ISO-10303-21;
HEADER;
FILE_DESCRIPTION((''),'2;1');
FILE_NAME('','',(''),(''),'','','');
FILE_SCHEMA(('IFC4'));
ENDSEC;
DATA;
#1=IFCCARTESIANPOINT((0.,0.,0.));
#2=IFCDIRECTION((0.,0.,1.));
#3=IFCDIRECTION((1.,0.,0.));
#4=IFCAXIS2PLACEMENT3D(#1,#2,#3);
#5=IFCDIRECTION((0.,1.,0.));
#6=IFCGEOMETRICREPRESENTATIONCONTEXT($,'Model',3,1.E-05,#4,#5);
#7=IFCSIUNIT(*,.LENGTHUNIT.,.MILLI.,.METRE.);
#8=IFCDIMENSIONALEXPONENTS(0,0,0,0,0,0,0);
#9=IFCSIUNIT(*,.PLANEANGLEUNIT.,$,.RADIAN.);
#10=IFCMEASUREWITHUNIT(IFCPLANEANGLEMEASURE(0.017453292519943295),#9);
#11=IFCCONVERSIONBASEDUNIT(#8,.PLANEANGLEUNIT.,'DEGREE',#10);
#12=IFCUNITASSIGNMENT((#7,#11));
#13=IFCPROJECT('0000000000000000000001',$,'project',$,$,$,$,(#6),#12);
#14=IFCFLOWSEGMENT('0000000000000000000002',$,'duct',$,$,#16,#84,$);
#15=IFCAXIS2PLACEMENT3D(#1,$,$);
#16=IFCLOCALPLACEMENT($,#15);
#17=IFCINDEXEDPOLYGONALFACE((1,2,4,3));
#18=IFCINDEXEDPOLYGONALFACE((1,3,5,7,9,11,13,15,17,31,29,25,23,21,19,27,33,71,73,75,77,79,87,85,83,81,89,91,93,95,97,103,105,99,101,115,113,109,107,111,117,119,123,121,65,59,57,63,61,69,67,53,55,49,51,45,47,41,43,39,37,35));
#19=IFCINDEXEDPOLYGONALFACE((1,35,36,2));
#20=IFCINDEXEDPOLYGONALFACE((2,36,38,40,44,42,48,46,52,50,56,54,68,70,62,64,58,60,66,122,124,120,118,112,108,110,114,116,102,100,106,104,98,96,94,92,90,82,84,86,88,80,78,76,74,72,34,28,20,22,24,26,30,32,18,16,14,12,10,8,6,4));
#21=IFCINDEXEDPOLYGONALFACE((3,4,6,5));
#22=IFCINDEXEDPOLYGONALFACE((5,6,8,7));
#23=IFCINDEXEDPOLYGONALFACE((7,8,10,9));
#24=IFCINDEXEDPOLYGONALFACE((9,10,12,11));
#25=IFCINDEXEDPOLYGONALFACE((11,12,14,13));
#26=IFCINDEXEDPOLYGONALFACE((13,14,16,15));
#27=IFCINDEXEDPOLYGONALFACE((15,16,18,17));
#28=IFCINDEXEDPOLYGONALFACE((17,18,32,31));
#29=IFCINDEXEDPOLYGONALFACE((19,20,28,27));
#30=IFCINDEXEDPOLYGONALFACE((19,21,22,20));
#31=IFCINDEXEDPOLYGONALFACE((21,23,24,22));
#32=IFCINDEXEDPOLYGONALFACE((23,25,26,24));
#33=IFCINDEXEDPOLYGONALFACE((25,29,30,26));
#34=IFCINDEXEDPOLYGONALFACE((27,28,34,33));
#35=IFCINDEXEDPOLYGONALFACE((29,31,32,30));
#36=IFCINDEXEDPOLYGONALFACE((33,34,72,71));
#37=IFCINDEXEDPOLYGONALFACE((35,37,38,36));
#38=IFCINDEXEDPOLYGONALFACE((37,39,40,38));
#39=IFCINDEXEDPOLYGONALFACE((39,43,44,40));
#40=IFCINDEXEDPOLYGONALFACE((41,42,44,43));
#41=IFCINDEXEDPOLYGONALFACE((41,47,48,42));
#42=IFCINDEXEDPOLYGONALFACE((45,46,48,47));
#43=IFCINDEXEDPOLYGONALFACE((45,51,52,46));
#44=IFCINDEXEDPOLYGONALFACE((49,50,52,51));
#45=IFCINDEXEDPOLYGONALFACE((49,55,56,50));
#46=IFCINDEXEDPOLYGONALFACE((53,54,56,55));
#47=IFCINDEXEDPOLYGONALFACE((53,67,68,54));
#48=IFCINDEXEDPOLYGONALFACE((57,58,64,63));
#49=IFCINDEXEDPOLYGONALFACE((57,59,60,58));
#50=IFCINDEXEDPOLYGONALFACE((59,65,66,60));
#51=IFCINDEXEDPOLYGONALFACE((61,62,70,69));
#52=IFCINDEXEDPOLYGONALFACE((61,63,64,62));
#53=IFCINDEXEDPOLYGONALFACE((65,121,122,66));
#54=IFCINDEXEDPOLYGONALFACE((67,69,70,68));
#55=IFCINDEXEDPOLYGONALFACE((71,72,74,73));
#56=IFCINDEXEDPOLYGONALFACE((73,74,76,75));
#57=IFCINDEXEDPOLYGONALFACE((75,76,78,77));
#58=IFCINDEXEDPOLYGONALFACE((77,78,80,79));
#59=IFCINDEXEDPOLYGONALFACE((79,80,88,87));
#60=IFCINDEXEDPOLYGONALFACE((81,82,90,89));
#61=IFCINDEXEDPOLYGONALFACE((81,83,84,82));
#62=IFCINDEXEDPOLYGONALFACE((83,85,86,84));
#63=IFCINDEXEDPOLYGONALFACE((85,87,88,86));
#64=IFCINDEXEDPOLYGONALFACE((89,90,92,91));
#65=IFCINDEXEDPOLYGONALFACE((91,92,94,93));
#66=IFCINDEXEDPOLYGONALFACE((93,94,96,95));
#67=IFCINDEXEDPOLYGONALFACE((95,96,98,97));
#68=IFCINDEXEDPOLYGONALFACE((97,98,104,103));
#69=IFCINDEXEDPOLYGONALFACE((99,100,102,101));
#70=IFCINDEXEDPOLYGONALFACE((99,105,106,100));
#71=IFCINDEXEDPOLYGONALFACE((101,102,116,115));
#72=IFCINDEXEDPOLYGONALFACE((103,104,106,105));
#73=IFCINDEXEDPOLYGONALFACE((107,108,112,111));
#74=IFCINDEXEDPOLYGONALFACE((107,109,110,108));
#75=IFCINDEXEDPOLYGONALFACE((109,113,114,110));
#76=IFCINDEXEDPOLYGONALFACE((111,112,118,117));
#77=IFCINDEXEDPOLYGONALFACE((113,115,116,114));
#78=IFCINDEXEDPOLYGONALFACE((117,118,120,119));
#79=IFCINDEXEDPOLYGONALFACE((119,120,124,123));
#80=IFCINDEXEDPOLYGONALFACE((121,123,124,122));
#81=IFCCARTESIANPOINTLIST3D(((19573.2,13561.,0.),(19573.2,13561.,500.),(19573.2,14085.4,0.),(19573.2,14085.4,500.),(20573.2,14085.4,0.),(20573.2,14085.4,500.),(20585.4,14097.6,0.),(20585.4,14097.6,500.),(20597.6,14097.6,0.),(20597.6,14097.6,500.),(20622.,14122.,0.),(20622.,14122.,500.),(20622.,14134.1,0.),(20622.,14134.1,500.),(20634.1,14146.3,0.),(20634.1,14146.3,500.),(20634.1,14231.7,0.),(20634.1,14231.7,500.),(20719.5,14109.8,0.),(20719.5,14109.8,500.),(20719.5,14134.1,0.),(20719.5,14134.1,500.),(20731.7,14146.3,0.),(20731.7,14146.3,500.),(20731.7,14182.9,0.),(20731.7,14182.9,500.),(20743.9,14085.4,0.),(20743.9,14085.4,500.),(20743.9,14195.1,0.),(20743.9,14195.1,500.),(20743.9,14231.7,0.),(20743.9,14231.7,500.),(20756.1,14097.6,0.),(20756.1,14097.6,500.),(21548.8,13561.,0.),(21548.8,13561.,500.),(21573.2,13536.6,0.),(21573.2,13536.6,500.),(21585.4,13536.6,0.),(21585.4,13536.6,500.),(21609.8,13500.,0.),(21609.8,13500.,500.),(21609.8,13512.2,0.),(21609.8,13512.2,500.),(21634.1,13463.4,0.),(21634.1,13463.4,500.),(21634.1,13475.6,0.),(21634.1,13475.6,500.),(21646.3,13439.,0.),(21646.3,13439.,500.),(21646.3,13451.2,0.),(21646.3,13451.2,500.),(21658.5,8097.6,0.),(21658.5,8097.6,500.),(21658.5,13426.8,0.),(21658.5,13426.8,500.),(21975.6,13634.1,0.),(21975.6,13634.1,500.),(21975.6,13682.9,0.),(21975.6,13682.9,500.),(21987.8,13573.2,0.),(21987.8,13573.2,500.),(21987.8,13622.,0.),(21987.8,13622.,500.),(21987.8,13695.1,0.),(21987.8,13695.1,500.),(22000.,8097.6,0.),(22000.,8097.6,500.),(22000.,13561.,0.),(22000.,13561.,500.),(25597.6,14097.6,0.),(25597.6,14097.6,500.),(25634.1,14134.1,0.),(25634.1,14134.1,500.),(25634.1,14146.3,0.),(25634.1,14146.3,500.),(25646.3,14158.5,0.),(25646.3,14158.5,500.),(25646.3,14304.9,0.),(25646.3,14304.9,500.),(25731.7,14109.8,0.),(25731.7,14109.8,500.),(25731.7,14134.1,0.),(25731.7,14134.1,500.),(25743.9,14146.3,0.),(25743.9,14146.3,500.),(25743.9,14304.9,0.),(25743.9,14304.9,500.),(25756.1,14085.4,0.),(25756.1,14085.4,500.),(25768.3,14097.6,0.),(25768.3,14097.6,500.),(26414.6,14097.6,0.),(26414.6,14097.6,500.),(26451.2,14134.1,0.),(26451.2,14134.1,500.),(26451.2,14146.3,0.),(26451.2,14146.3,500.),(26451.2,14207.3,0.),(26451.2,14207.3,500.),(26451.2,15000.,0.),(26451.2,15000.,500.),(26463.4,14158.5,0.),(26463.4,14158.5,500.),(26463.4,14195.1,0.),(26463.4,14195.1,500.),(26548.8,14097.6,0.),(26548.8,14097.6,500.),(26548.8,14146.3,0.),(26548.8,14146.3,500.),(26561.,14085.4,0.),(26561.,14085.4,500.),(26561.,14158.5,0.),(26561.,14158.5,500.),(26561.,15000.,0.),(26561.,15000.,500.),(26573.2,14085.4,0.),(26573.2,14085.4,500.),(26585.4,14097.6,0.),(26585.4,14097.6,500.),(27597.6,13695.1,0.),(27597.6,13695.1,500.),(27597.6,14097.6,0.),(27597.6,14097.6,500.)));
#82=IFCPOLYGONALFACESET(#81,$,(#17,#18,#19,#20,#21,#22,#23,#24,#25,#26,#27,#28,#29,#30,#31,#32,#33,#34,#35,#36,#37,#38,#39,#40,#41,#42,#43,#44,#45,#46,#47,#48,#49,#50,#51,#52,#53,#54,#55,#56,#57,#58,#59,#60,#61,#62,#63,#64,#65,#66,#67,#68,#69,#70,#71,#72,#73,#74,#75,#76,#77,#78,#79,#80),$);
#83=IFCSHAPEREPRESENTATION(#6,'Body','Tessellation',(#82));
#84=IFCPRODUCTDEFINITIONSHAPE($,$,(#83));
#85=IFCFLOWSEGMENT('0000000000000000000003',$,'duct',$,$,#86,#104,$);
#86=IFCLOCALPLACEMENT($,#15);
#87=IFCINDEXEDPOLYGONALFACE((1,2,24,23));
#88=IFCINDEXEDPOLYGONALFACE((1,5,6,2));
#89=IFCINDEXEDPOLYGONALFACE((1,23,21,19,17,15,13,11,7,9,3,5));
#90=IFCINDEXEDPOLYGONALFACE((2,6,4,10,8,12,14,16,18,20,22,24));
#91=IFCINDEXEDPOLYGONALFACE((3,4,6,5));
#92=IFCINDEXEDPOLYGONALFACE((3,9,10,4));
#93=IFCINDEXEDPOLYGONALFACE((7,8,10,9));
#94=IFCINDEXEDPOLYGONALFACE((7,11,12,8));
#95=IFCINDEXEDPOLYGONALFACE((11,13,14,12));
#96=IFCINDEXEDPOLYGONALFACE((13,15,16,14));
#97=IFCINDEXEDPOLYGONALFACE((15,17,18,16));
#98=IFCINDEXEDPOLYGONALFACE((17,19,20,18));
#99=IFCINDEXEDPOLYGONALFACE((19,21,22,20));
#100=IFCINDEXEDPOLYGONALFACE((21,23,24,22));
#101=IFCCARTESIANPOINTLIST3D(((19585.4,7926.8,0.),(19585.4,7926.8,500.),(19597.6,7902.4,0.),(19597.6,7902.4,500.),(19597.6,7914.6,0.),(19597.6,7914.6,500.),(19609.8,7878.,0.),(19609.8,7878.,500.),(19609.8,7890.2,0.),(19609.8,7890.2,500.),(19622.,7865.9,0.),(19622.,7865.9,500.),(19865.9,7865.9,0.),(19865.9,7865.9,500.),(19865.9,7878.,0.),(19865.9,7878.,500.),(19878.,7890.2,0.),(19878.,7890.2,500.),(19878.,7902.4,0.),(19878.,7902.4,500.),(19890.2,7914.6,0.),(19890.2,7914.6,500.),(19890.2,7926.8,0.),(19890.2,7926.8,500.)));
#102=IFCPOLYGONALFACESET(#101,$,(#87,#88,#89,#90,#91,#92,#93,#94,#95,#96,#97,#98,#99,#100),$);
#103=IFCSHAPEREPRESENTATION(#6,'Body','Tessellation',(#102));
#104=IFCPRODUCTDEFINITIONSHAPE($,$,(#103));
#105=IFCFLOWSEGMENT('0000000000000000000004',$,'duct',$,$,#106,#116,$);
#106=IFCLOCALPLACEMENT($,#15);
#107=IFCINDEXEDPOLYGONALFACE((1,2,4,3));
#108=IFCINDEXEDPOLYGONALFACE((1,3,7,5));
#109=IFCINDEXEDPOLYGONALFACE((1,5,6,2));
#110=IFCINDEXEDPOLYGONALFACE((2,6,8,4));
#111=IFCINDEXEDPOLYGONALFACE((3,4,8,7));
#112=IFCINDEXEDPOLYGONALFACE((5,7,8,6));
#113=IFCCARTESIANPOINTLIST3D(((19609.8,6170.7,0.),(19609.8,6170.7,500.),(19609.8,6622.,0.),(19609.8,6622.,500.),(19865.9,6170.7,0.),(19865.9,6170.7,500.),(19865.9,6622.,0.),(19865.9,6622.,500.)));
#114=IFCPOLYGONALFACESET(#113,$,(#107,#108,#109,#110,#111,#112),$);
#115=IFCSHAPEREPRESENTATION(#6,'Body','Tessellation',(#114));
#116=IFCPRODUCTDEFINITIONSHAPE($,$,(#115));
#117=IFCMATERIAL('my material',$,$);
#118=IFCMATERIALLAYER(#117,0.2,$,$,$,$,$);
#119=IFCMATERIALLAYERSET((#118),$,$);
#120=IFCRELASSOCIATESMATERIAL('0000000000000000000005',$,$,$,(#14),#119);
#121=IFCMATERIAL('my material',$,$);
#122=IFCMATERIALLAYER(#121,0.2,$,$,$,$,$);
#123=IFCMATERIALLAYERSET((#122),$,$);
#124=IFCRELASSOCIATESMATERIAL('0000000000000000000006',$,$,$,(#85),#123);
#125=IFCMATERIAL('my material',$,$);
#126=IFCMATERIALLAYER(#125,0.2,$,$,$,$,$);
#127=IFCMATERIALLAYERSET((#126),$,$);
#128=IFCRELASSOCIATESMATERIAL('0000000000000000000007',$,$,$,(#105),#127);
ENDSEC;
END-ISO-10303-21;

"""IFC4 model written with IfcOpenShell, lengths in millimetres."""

from ifc_helpers import new_model, entity, si_unit, converted_unit, direction, origin_with_axes, place, context, project, polyline, outline, extrude, material, layer, layer_set, layer_usage, element, save


model = new_model("IFC4")

# Units and contexts
model_context = context("Model", 3, precision=1e-05, world=origin_with_axes(), true_north=direction((0.0, 1.0, 0.0)))
ifc_project = project(units=[si_unit("LENGTHUNIT", "METRE", prefix="MILLI"), converted_unit("PLANEANGLEUNIT", "DEGREE", entity("IfcPlaneAngleMeasure", 0.017453292519943295), si_unit("PLANEANGLEUNIT", "RADIAN"), dimensions=[0, 0, 0, 0, 0, 0, 0])], contexts=[model_context])

# Flow segments
ifc_material_1 = material(Name="my material")
ifc_layer_1 = layer(ifc_material_1, 0.2)
ifc_layer_set_1 = layer_set([ifc_layer_1])
ifc_layer_usage_1 = layer_usage(ifc_layer_set_1, "AXIS2", "POSITIVE", -0.1)
flow_segment_1_placement = place(None, origin_with_axes())
element("IfcFlowSegment", 1, at=flow_segment_1_placement, material=ifc_layer_usage_1, Name="duct", context=model_context, shape_type="SweptSolid", body=[
    extrude(outline(polyline([(19573.2, 13561.0), (21548.8, 13561.0), (21573.2, 13536.6), (21585.4, 13536.6), (21609.8, 13512.2), (21609.8, 13500.0), (21634.1, 13475.6), (21634.1, 13463.4), (21646.3, 13451.2), (21646.3, 13439.0), (21658.5, 13426.8), (21658.5, 8097.6), (22000.0, 8097.6), (22000.0, 13561.0), (21987.8, 13573.2), (21987.8, 13622.0), (21975.6, 13634.1), (21975.6, 13682.9), (21987.8, 13695.1), (27597.6, 13695.1), (27597.6, 14097.6), (26585.4, 14097.6), (26573.2, 14085.4), (26561.0, 14085.4), (26548.8, 14097.6), (26548.8, 14146.3), (26561.0, 14158.5), (26561.0, 15000.0), (26451.2, 15000.0), (26451.2, 14207.3), (26463.4, 14195.1), (26463.4, 14158.5), (26451.2, 14146.3), (26451.2, 14134.1), (26414.6, 14097.6), (25768.3, 14097.6), (25756.1, 14085.4), (25731.7, 14109.8), (25731.7, 14134.1), (25743.9, 14146.3), (25743.9, 14304.9), (25646.3, 14304.9), (25646.3, 14158.5), (25634.1, 14146.3), (25634.1, 14134.1), (25597.6, 14097.6), (20756.1, 14097.6), (20743.9, 14085.4), (20719.5, 14109.8), (20719.5, 14134.1), (20731.7, 14146.3), (20731.7, 14182.9), (20743.9, 14195.1), (20743.9, 14231.7), (20634.1, 14231.7), (20634.1, 14146.3), (20622.0, 14134.1), (20622.0, 14122.0), (20597.6, 14097.6), (20585.4, 14097.6), (20573.2, 14085.4), (19573.2, 14085.4), (19573.2, 13561.0)])), origin_with_axes(), (0.0, 0.0, 1.0), 500.0),
])
ifc_material_2 = material(Name="my material")
ifc_layer_2 = layer(ifc_material_2, 0.2)
ifc_layer_set_2 = layer_set([ifc_layer_2])
ifc_layer_usage_2 = layer_usage(ifc_layer_set_2, "AXIS2", "POSITIVE", -0.1)
flow_segment_2_placement = place(None, origin_with_axes())
element("IfcFlowSegment", 2, at=flow_segment_2_placement, material=ifc_layer_usage_2, Name="duct", context=model_context, shape_type="SweptSolid", body=[
    extrude(outline(polyline([(19585.4, 7926.8), (19597.6, 7914.6), (19597.6, 7902.4), (19609.8, 7890.2), (19609.8, 7878.0), (19622.0, 7865.9), (19865.9, 7865.9), (19865.9, 7878.0), (19878.0, 7890.2), (19878.0, 7902.4), (19890.2, 7914.6), (19890.2, 7926.8), (19585.4, 7926.8)])), origin_with_axes(), (0.0, 0.0, 1.0), 500.0),
])
ifc_material_3 = material(Name="my material")
ifc_layer_3 = layer(ifc_material_3, 0.2)
ifc_layer_set_3 = layer_set([ifc_layer_3])
ifc_layer_usage_3 = layer_usage(ifc_layer_set_3, "AXIS2", "POSITIVE", -0.1)
flow_segment_3_placement = place(None, origin_with_axes())
element("IfcFlowSegment", 3, at=flow_segment_3_placement, material=ifc_layer_usage_3, Name="duct", context=model_context, shape_type="SweptSolid", body=[
    extrude(outline(polyline([(19609.8, 6170.7), (19865.9, 6170.7), (19865.9, 6622.0), (19609.8, 6622.0), (19609.8, 6170.7)])), origin_with_axes(), (0.0, 0.0, 1.0), 500.0),
])

save(model, "model.ifc")
